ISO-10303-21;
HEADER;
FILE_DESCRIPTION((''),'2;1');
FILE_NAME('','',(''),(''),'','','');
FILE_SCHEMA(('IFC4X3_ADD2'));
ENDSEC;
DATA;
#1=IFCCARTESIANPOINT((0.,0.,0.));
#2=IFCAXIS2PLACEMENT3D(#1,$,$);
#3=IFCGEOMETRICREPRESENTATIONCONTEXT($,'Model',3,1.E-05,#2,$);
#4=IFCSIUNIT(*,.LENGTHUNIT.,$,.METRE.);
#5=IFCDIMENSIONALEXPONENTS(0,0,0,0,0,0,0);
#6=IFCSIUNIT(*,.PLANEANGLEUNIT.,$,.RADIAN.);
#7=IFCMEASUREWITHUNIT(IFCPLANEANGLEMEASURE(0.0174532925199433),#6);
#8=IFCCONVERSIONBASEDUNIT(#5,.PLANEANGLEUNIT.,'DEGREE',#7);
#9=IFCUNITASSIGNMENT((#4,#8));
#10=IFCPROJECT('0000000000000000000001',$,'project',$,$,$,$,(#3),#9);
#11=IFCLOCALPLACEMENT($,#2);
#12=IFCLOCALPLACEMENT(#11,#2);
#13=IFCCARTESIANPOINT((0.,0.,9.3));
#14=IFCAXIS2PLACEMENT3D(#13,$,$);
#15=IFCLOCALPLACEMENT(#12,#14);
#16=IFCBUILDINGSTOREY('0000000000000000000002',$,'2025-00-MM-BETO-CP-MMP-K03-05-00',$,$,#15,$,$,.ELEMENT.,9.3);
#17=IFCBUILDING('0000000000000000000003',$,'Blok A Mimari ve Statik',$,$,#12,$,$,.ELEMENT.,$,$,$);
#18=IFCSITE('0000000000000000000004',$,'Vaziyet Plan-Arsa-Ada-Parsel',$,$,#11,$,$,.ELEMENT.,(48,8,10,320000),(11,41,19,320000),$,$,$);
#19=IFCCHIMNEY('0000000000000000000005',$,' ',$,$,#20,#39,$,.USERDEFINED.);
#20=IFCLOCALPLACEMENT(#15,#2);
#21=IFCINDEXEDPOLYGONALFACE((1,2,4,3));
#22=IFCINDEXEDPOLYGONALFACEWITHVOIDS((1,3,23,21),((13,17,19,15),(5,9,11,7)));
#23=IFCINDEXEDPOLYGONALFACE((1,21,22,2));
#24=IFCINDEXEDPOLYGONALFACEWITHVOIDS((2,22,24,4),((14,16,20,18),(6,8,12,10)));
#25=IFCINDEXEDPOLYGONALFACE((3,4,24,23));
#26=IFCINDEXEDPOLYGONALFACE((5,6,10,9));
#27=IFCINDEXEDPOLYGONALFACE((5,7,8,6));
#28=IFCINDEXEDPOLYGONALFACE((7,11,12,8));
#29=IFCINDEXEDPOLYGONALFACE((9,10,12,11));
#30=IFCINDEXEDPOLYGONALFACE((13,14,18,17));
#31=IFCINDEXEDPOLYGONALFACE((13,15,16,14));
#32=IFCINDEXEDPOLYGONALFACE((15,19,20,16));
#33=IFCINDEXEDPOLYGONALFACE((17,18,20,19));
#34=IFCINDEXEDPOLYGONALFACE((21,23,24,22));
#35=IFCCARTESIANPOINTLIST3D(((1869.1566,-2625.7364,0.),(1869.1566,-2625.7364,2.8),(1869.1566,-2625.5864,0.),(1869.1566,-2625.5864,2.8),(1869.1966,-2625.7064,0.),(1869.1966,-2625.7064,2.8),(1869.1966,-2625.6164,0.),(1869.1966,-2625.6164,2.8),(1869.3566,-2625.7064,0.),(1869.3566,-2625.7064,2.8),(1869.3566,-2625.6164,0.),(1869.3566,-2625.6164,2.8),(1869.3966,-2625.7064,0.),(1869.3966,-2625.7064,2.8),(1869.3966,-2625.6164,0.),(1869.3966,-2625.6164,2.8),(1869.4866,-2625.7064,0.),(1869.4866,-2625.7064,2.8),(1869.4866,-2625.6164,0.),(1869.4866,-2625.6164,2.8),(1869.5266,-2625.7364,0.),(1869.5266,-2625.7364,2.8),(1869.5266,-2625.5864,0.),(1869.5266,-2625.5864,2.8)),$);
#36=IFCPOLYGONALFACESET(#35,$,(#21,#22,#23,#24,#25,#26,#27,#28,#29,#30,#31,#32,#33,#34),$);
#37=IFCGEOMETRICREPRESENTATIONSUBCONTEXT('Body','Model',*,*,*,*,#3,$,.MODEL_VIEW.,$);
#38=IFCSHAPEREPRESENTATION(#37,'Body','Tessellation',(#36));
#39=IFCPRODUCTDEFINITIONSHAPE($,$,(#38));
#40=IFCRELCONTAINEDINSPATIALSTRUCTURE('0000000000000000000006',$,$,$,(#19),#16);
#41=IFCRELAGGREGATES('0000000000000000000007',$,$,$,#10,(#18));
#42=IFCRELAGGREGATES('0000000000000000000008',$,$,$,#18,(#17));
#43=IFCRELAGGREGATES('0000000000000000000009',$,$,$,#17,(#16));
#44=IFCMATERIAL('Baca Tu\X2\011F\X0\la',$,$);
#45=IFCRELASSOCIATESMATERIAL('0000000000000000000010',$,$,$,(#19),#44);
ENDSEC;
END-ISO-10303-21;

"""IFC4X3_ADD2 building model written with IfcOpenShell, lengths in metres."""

from ifc_helpers import new_model, entity, si_unit, converted_unit, frame, origin, origin_with_axes, place, context, subcontext, project, spatial, polyline, outline, extrude, material, element, save


model = new_model("IFC4X3_ADD2")

# Units and contexts
model_context = context("Model", 3, precision=1e-05, world=origin())
body_context = subcontext(model_context, "Body", "Model", "MODEL_VIEW")
ifc_project = project(units=[si_unit("LENGTHUNIT", "METRE"), converted_unit("PLANEANGLEUNIT", "DEGREE", entity("IfcPlaneAngleMeasure", 0.0174532925199433), si_unit("PLANEANGLEUNIT", "RADIAN"), dimensions=[0, 0, 0, 0, 0, 0, 0])], contexts=[model_context])

# Site, building, storey
site_placement = place(None, origin())
site = spatial("IfcSite", under=ifc_project, at=site_placement, Name="Vaziyet Plan-Arsa-Ada-Parsel", CompositionType="ELEMENT", RefLatitude=(48, 8, 10, 320000), RefLongitude=(11, 41, 19, 320000))
building_placement = place(site_placement, origin())
building = spatial("IfcBuilding", under=site, at=building_placement, Name="Blok A Mimari ve Statik", CompositionType="ELEMENT")
storey_placement = place(building_placement, frame((0.0, 0.0, 9.3)))
storey = spatial("IfcBuildingStorey", under=building, at=storey_placement, Name="2025-00-MM-BETO-CP-MMP-K03-05-00", CompositionType="ELEMENT", Elevation=9.3)

# Chimney
ifc_material_1 = material(Name="Baca Tuğla")
chimney_placement = place(storey_placement, frame((1869.1566, -2625.7364, 0.0)))
element("IfcChimney", 1, at=chimney_placement, inside=storey, material=ifc_material_1, Name=" ", PredefinedType="USERDEFINED", context=body_context, shape_type="SweptSolid", body=[
    extrude(outline(polyline([(0.0, 0.0), (0.37, 0.0), (0.37, 0.15), (0.0, 0.15), (0.0, 0.0)]), holes=[polyline([(0.04, 0.03), (0.04, 0.12), (0.2, 0.12), (0.2, 0.03), (0.04, 0.03)]), polyline([(0.24, 0.03), (0.24, 0.12), (0.33, 0.12), (0.33, 0.03), (0.24, 0.03)])]), origin_with_axes(), (0.0, 0.0, 1.0), 2.8),
])

save(model, "model.ifc")
